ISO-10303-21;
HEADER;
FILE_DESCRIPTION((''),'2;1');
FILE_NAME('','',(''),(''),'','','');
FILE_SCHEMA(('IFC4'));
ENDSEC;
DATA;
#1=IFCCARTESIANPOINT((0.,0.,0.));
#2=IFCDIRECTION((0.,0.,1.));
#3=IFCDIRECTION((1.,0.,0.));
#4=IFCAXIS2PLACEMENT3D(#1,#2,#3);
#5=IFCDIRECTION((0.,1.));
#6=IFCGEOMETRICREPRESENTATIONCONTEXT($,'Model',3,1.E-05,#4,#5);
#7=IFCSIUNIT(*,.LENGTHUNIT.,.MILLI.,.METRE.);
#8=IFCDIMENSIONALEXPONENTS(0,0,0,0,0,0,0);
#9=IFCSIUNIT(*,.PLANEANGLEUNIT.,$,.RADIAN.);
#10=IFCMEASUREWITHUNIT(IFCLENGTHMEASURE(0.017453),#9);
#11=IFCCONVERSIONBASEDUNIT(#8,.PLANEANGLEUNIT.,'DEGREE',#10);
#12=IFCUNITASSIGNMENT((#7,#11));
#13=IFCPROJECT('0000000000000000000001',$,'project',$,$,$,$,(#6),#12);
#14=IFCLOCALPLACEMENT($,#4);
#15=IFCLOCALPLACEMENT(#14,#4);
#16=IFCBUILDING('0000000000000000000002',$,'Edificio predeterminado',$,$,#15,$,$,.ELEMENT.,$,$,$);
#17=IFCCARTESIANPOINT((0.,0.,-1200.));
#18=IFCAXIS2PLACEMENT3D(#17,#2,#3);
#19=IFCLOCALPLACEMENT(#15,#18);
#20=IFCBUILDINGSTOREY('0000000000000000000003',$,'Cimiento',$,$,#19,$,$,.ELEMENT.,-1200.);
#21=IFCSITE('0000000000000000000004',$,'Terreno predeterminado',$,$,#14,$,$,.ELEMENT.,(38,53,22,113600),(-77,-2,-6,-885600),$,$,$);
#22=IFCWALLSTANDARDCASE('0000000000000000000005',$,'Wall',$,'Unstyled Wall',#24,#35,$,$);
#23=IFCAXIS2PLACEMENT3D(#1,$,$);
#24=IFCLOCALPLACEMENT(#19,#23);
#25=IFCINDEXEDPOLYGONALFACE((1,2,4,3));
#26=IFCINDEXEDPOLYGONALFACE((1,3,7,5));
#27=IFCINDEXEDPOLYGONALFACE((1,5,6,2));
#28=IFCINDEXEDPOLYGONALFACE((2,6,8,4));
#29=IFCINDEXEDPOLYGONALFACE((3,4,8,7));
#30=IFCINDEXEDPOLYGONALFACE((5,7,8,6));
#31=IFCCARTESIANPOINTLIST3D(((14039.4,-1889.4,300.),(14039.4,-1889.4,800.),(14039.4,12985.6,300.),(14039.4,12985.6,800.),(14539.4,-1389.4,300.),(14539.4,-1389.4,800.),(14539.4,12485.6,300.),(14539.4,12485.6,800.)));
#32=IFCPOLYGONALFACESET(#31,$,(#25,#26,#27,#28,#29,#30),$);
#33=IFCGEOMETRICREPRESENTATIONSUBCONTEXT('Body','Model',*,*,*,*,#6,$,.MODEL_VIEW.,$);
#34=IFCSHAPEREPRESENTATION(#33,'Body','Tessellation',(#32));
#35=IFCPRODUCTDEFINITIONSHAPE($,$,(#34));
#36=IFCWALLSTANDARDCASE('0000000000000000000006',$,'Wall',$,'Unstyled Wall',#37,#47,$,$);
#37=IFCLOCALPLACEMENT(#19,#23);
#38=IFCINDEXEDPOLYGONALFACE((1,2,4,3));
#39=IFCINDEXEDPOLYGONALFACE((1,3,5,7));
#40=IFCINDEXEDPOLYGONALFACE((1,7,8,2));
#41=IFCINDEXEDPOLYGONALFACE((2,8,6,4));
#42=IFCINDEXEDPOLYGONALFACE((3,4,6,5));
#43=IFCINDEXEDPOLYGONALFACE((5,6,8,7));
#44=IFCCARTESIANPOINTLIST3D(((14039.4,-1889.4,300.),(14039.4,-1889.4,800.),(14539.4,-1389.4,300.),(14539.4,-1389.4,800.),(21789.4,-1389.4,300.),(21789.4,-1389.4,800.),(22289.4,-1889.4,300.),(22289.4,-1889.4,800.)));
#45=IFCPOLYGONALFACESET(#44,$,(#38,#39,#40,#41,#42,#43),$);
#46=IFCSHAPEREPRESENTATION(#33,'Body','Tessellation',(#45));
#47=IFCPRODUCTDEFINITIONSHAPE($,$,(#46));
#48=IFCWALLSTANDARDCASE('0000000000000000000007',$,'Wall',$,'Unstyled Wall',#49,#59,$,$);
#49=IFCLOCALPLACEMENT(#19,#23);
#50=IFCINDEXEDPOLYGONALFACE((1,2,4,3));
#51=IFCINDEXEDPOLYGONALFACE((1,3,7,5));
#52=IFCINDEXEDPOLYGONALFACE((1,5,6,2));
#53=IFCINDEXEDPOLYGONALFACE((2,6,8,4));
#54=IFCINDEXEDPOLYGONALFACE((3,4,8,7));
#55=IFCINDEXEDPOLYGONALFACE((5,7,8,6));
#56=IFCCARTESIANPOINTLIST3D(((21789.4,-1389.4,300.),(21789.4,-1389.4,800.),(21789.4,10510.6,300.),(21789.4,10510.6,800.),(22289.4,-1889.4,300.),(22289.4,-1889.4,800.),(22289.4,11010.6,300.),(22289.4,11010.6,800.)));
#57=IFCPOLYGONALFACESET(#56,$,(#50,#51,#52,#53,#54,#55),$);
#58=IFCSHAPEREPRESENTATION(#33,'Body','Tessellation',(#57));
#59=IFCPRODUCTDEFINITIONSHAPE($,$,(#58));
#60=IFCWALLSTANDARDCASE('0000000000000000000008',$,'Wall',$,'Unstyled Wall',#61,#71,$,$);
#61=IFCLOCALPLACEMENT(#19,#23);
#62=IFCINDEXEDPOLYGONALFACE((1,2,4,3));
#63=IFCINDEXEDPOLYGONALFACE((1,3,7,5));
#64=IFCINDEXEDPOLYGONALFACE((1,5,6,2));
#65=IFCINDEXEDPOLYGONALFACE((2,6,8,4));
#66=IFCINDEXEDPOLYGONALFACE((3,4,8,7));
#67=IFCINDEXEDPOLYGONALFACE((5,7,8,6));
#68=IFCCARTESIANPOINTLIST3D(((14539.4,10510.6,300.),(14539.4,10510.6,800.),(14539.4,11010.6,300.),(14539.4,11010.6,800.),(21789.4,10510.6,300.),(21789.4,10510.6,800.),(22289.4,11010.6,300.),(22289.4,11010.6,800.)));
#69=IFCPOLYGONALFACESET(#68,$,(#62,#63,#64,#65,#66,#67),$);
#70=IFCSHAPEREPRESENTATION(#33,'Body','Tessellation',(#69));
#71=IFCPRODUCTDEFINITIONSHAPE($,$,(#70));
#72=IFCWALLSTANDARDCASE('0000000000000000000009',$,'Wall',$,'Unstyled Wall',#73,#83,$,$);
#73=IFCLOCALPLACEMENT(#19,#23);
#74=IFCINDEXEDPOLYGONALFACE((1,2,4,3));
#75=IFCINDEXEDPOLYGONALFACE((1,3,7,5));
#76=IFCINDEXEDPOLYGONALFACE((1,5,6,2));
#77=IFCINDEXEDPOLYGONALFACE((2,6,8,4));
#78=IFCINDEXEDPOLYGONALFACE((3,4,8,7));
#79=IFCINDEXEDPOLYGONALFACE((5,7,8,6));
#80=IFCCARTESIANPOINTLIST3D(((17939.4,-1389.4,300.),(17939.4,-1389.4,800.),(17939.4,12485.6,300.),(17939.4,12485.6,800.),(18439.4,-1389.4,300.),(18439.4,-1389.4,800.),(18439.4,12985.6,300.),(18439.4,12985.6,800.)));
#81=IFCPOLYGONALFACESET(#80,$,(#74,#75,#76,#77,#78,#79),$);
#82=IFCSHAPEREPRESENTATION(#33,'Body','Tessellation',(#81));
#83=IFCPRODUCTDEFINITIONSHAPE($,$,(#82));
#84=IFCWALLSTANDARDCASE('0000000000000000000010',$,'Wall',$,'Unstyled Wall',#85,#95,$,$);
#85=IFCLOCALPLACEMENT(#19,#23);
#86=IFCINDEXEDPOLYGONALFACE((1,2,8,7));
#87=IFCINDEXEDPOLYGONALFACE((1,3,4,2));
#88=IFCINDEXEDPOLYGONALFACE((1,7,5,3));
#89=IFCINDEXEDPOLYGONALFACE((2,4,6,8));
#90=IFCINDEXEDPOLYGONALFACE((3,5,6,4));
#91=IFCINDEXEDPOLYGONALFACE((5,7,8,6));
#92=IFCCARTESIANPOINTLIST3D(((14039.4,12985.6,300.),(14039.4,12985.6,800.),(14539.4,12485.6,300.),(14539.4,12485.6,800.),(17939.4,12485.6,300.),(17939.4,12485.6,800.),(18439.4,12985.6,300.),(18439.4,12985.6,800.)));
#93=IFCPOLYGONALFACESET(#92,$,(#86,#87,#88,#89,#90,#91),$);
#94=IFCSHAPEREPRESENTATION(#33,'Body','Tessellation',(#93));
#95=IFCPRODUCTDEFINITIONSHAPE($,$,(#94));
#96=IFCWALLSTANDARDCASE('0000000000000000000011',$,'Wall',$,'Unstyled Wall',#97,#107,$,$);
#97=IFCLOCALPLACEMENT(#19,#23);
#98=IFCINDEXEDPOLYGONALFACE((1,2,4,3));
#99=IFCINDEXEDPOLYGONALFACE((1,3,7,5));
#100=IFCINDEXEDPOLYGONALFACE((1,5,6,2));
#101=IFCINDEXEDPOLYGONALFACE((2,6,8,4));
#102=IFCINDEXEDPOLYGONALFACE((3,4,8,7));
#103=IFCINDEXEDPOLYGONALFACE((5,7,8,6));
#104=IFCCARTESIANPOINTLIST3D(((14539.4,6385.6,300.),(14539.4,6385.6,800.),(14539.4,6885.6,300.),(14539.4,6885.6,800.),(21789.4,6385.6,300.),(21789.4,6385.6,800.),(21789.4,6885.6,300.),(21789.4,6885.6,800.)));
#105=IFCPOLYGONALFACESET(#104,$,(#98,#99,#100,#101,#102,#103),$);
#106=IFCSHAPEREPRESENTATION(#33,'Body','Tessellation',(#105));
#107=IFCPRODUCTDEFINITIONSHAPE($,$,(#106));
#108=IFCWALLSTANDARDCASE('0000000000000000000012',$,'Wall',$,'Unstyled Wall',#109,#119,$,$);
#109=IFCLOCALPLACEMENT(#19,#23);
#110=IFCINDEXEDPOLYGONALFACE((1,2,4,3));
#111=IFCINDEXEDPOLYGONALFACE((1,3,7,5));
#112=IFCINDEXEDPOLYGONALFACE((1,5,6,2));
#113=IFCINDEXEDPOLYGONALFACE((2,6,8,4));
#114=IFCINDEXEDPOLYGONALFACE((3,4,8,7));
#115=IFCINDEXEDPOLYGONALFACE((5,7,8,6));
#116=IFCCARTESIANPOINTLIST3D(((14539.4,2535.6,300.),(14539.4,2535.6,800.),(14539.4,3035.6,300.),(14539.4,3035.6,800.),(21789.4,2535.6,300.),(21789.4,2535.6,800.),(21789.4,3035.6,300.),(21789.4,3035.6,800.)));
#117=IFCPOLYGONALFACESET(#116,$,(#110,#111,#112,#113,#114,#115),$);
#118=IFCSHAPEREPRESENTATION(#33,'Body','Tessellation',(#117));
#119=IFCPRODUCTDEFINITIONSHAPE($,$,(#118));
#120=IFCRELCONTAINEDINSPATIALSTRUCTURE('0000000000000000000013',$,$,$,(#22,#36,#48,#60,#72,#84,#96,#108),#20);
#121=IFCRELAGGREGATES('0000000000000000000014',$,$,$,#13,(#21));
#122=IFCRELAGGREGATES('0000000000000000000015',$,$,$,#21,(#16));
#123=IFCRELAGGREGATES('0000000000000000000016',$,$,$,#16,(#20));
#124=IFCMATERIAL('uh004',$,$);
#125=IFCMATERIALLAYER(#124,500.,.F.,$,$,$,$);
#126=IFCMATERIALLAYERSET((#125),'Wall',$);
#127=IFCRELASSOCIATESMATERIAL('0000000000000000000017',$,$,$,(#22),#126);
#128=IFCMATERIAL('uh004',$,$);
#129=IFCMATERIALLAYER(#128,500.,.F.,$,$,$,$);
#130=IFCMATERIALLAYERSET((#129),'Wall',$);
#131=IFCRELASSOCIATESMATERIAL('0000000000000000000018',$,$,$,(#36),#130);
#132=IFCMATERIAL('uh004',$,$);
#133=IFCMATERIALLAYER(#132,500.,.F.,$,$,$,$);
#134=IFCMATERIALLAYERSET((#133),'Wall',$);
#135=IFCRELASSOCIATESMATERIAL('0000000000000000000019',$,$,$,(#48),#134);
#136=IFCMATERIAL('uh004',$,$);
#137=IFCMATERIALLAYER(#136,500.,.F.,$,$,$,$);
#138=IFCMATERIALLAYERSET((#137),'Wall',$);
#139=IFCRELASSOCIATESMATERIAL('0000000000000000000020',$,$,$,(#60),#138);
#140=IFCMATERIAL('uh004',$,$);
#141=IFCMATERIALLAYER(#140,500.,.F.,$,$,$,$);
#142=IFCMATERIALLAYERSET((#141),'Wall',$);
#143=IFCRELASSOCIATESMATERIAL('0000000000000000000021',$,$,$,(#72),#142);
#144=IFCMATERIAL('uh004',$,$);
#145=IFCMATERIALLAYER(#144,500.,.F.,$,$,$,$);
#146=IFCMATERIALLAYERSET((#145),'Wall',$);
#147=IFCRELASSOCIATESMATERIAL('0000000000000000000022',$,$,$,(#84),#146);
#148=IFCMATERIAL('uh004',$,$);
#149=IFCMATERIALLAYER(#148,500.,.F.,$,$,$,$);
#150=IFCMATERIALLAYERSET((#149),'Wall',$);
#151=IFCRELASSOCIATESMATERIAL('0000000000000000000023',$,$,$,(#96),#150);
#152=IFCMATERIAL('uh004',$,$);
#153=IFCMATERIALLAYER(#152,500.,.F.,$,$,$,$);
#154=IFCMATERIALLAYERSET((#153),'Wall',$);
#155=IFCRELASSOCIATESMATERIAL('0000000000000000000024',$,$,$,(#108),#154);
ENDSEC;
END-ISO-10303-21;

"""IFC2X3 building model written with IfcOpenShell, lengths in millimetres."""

from ifc_helpers import new_model, entity, si_unit, converted_unit, direction, frame, origin_with_axes, place, context, subcontext, project, spatial, polyline, outline, extrude, material, layer, layer_set, layer_usage, element, save


model = new_model("IFC2X3")

# Units and contexts
model_context = context("Model", 3, precision=1e-05, world=origin_with_axes(), true_north=direction((0.0, 1.0)))
body_context = subcontext(model_context, "Body", "Model", "MODEL_VIEW")
ifc_project = project(units=[si_unit("LENGTHUNIT", "METRE", prefix="MILLI"), converted_unit("PLANEANGLEUNIT", "DEGREE", entity("IfcLengthMeasure", 0.017453), si_unit("PLANEANGLEUNIT", "RADIAN"), dimensions=[0, 0, 0, 0, 0, 0, 0])], contexts=[model_context])

# Site, building, storey
site_placement = place(None, origin_with_axes())
site = spatial("IfcSite", under=ifc_project, at=site_placement, Name="Terreno predeterminado", CompositionType="ELEMENT", RefLatitude=(38, 53, 22, 113600), RefLongitude=(-77, -2, -6, -885600))
building_placement = place(site_placement, origin_with_axes())
building = spatial("IfcBuilding", under=site, at=building_placement, Name="Edificio predeterminado", CompositionType="ELEMENT")
storey_placement = place(building_placement, frame((0.0, 0.0, -1200.0), z_axis=(0.0, 0.0, 1.0), x_axis=(1.0, 0.0, 0.0)))
storey = spatial("IfcBuildingStorey", under=building, at=storey_placement, Name="Cimiento", CompositionType="ELEMENT", Elevation=-1200.0)

# Walls
ifc_material_1 = material(Name="uh004")
ifc_layer_1 = layer(ifc_material_1, 500.0, ventilated=False)
ifc_layer_set_1 = layer_set([ifc_layer_1], Name="Wall")
ifc_layer_usage_1 = layer_usage(ifc_layer_set_1, "AXIS2", "POSITIVE", -250.0)
wall_1_placement = place(storey_placement, frame((14289.4, 12735.6, 300.0), z_axis=(0.0, 0.0, 1.0), x_axis=(0.0, -1.0, 0.0)))
element("IfcWallStandardCase", 1, at=wall_1_placement, inside=storey, material=ifc_layer_usage_1, Name="Wall", ObjectType="Unstyled Wall", context=body_context, shape_type="SweptSolid", body=[
    extrude(outline(polyline([(250.0, 250.0), (-250.0, -250.0), (14625.0, -250.0), (14125.0, 250.0), (250.0, 250.0)])), origin_with_axes(), (0.0, 0.0, 1.0), 500.0),
])
ifc_material_2 = material(Name="uh004")
ifc_layer_2 = layer(ifc_material_2, 500.0, ventilated=False)
ifc_layer_set_2 = layer_set([ifc_layer_2], Name="Wall")
ifc_layer_usage_2 = layer_usage(ifc_layer_set_2, "AXIS2", "POSITIVE", -250.0)
wall_2_placement = place(storey_placement, frame((14289.4, -1639.4, 300.0), z_axis=(0.0, 0.0, 1.0), x_axis=(1.0, 0.0, 0.0)))
element("IfcWallStandardCase", 2, at=wall_2_placement, inside=storey, material=ifc_layer_usage_2, Name="Wall", ObjectType="Unstyled Wall", context=body_context, shape_type="SweptSolid", body=[
    extrude(outline(polyline([(-250.0, -250.0), (250.0, 250.0), (7500.0, 250.0), (8000.0, -250.0), (-250.0, -250.0)])), origin_with_axes(), (0.0, 0.0, 1.0), 500.0),
])
ifc_material_3 = material(Name="uh004")
ifc_layer_3 = layer(ifc_material_3, 500.0, ventilated=False)
ifc_layer_set_3 = layer_set([ifc_layer_3], Name="Wall")
ifc_layer_usage_3 = layer_usage(ifc_layer_set_3, "AXIS2", "POSITIVE", -250.0)
wall_3_placement = place(storey_placement, frame((22039.4, -1639.4, 300.0), z_axis=(0.0, 0.0, 1.0), x_axis=(0.0, 1.0, 0.0)))
element("IfcWallStandardCase", 3, at=wall_3_placement, inside=storey, material=ifc_layer_usage_3, Name="Wall", ObjectType="Unstyled Wall", context=body_context, shape_type="SweptSolid", body=[
    extrude(outline(polyline([(-250.0, -250.0), (250.0, 250.0), (12150.0, 250.0), (12650.0, -250.0), (-250.0, -250.0)])), origin_with_axes(), (0.0, 0.0, 1.0), 500.0),
])
ifc_material_4 = material(Name="uh004")
ifc_layer_4 = layer(ifc_material_4, 500.0, ventilated=False)
ifc_layer_set_4 = layer_set([ifc_layer_4], Name="Wall")
ifc_layer_usage_4 = layer_usage(ifc_layer_set_4, "AXIS2", "POSITIVE", -250.0)
wall_4_placement = place(storey_placement, frame((22039.4, 10760.6, 300.0), z_axis=(0.0, 0.0, 1.0), x_axis=(-1.0, 0.0, 0.0)))
element("IfcWallStandardCase", 4, at=wall_4_placement, inside=storey, material=ifc_layer_usage_4, Name="Wall", ObjectType="Unstyled Wall", context=body_context, shape_type="SweptSolid", body=[
    extrude(outline(polyline([(-250.0, -250.0), (250.0, 250.0), (7500.0, 250.0), (7500.0, -250.0), (-250.0, -250.0)])), origin_with_axes(), (0.0, 0.0, 1.0), 500.0),
])
ifc_material_5 = material(Name="uh004")
ifc_layer_5 = layer(ifc_material_5, 500.0, ventilated=False)
ifc_layer_set_5 = layer_set([ifc_layer_5], Name="Wall")
ifc_layer_usage_5 = layer_usage(ifc_layer_set_5, "AXIS2", "POSITIVE", -250.0)
wall_5_placement = place(storey_placement, frame((18189.4, -1639.4, 300.0), z_axis=(0.0, 0.0, 1.0), x_axis=(0.0, 1.0, 0.0)))
element("IfcWallStandardCase", 5, at=wall_5_placement, inside=storey, material=ifc_layer_usage_5, Name="Wall", ObjectType="Unstyled Wall", context=body_context, shape_type="SweptSolid", body=[
    extrude(outline(polyline([(250.0, 250.0), (250.0, -250.0), (14625.0, -250.0), (14125.0, 250.0), (250.0, 250.0)])), origin_with_axes(), (0.0, 0.0, 1.0), 500.0),
])
ifc_material_6 = material(Name="uh004")
ifc_layer_6 = layer(ifc_material_6, 500.0, ventilated=False)
ifc_layer_set_6 = layer_set([ifc_layer_6], Name="Wall")
ifc_layer_usage_6 = layer_usage(ifc_layer_set_6, "AXIS2", "POSITIVE", -250.0)
wall_6_placement = place(storey_placement, frame((18189.4, 12735.6, 300.0), z_axis=(0.0, 0.0, 1.0), x_axis=(-1.0, 0.0, 0.0)))
element("IfcWallStandardCase", 6, at=wall_6_placement, inside=storey, material=ifc_layer_usage_6, Name="Wall", ObjectType="Unstyled Wall", context=body_context, shape_type="SweptSolid", body=[
    extrude(outline(polyline([(-250.0, -250.0), (250.0, 250.0), (3650.0, 250.0), (4150.0, -250.0), (-250.0, -250.0)])), origin_with_axes(), (0.0, 0.0, 1.0), 500.0),
])
ifc_material_7 = material(Name="uh004")
ifc_layer_7 = layer(ifc_material_7, 500.0, ventilated=False)
ifc_layer_set_7 = layer_set([ifc_layer_7], Name="Wall")
ifc_layer_usage_7 = layer_usage(ifc_layer_set_7, "AXIS2", "POSITIVE", -250.0)
wall_7_placement = place(storey_placement, frame((14289.4, 6635.6, 300.0), z_axis=(0.0, 0.0, 1.0), x_axis=(1.0, 0.0, 0.0)))
element("IfcWallStandardCase", 7, at=wall_7_placement, inside=storey, material=ifc_layer_usage_7, Name="Wall", ObjectType="Unstyled Wall", context=body_context, shape_type="SweptSolid", body=[
    extrude(outline(polyline([(250.0, -250.0), (250.0, 250.0), (7500.0, 250.0), (7500.0, -250.0), (250.0, -250.0)])), origin_with_axes(), (0.0, 0.0, 1.0), 500.0),
])
ifc_material_8 = material(Name="uh004")
ifc_layer_8 = layer(ifc_material_8, 500.0, ventilated=False)
ifc_layer_set_8 = layer_set([ifc_layer_8], Name="Wall")
ifc_layer_usage_8 = layer_usage(ifc_layer_set_8, "AXIS2", "POSITIVE", -250.0)
wall_8_placement = place(storey_placement, frame((14289.4, 2785.6, 300.0), z_axis=(0.0, 0.0, 1.0), x_axis=(1.0, 0.0, 0.0)))
element("IfcWallStandardCase", 8, at=wall_8_placement, inside=storey, material=ifc_layer_usage_8, Name="Wall", ObjectType="Unstyled Wall", context=body_context, shape_type="SweptSolid", body=[
    extrude(outline(polyline([(250.0, -250.0), (250.0, 250.0), (7500.0, 250.0), (7500.0, -250.0), (250.0, -250.0)])), origin_with_axes(), (0.0, 0.0, 1.0), 500.0),
])

save(model, "model.ifc")
